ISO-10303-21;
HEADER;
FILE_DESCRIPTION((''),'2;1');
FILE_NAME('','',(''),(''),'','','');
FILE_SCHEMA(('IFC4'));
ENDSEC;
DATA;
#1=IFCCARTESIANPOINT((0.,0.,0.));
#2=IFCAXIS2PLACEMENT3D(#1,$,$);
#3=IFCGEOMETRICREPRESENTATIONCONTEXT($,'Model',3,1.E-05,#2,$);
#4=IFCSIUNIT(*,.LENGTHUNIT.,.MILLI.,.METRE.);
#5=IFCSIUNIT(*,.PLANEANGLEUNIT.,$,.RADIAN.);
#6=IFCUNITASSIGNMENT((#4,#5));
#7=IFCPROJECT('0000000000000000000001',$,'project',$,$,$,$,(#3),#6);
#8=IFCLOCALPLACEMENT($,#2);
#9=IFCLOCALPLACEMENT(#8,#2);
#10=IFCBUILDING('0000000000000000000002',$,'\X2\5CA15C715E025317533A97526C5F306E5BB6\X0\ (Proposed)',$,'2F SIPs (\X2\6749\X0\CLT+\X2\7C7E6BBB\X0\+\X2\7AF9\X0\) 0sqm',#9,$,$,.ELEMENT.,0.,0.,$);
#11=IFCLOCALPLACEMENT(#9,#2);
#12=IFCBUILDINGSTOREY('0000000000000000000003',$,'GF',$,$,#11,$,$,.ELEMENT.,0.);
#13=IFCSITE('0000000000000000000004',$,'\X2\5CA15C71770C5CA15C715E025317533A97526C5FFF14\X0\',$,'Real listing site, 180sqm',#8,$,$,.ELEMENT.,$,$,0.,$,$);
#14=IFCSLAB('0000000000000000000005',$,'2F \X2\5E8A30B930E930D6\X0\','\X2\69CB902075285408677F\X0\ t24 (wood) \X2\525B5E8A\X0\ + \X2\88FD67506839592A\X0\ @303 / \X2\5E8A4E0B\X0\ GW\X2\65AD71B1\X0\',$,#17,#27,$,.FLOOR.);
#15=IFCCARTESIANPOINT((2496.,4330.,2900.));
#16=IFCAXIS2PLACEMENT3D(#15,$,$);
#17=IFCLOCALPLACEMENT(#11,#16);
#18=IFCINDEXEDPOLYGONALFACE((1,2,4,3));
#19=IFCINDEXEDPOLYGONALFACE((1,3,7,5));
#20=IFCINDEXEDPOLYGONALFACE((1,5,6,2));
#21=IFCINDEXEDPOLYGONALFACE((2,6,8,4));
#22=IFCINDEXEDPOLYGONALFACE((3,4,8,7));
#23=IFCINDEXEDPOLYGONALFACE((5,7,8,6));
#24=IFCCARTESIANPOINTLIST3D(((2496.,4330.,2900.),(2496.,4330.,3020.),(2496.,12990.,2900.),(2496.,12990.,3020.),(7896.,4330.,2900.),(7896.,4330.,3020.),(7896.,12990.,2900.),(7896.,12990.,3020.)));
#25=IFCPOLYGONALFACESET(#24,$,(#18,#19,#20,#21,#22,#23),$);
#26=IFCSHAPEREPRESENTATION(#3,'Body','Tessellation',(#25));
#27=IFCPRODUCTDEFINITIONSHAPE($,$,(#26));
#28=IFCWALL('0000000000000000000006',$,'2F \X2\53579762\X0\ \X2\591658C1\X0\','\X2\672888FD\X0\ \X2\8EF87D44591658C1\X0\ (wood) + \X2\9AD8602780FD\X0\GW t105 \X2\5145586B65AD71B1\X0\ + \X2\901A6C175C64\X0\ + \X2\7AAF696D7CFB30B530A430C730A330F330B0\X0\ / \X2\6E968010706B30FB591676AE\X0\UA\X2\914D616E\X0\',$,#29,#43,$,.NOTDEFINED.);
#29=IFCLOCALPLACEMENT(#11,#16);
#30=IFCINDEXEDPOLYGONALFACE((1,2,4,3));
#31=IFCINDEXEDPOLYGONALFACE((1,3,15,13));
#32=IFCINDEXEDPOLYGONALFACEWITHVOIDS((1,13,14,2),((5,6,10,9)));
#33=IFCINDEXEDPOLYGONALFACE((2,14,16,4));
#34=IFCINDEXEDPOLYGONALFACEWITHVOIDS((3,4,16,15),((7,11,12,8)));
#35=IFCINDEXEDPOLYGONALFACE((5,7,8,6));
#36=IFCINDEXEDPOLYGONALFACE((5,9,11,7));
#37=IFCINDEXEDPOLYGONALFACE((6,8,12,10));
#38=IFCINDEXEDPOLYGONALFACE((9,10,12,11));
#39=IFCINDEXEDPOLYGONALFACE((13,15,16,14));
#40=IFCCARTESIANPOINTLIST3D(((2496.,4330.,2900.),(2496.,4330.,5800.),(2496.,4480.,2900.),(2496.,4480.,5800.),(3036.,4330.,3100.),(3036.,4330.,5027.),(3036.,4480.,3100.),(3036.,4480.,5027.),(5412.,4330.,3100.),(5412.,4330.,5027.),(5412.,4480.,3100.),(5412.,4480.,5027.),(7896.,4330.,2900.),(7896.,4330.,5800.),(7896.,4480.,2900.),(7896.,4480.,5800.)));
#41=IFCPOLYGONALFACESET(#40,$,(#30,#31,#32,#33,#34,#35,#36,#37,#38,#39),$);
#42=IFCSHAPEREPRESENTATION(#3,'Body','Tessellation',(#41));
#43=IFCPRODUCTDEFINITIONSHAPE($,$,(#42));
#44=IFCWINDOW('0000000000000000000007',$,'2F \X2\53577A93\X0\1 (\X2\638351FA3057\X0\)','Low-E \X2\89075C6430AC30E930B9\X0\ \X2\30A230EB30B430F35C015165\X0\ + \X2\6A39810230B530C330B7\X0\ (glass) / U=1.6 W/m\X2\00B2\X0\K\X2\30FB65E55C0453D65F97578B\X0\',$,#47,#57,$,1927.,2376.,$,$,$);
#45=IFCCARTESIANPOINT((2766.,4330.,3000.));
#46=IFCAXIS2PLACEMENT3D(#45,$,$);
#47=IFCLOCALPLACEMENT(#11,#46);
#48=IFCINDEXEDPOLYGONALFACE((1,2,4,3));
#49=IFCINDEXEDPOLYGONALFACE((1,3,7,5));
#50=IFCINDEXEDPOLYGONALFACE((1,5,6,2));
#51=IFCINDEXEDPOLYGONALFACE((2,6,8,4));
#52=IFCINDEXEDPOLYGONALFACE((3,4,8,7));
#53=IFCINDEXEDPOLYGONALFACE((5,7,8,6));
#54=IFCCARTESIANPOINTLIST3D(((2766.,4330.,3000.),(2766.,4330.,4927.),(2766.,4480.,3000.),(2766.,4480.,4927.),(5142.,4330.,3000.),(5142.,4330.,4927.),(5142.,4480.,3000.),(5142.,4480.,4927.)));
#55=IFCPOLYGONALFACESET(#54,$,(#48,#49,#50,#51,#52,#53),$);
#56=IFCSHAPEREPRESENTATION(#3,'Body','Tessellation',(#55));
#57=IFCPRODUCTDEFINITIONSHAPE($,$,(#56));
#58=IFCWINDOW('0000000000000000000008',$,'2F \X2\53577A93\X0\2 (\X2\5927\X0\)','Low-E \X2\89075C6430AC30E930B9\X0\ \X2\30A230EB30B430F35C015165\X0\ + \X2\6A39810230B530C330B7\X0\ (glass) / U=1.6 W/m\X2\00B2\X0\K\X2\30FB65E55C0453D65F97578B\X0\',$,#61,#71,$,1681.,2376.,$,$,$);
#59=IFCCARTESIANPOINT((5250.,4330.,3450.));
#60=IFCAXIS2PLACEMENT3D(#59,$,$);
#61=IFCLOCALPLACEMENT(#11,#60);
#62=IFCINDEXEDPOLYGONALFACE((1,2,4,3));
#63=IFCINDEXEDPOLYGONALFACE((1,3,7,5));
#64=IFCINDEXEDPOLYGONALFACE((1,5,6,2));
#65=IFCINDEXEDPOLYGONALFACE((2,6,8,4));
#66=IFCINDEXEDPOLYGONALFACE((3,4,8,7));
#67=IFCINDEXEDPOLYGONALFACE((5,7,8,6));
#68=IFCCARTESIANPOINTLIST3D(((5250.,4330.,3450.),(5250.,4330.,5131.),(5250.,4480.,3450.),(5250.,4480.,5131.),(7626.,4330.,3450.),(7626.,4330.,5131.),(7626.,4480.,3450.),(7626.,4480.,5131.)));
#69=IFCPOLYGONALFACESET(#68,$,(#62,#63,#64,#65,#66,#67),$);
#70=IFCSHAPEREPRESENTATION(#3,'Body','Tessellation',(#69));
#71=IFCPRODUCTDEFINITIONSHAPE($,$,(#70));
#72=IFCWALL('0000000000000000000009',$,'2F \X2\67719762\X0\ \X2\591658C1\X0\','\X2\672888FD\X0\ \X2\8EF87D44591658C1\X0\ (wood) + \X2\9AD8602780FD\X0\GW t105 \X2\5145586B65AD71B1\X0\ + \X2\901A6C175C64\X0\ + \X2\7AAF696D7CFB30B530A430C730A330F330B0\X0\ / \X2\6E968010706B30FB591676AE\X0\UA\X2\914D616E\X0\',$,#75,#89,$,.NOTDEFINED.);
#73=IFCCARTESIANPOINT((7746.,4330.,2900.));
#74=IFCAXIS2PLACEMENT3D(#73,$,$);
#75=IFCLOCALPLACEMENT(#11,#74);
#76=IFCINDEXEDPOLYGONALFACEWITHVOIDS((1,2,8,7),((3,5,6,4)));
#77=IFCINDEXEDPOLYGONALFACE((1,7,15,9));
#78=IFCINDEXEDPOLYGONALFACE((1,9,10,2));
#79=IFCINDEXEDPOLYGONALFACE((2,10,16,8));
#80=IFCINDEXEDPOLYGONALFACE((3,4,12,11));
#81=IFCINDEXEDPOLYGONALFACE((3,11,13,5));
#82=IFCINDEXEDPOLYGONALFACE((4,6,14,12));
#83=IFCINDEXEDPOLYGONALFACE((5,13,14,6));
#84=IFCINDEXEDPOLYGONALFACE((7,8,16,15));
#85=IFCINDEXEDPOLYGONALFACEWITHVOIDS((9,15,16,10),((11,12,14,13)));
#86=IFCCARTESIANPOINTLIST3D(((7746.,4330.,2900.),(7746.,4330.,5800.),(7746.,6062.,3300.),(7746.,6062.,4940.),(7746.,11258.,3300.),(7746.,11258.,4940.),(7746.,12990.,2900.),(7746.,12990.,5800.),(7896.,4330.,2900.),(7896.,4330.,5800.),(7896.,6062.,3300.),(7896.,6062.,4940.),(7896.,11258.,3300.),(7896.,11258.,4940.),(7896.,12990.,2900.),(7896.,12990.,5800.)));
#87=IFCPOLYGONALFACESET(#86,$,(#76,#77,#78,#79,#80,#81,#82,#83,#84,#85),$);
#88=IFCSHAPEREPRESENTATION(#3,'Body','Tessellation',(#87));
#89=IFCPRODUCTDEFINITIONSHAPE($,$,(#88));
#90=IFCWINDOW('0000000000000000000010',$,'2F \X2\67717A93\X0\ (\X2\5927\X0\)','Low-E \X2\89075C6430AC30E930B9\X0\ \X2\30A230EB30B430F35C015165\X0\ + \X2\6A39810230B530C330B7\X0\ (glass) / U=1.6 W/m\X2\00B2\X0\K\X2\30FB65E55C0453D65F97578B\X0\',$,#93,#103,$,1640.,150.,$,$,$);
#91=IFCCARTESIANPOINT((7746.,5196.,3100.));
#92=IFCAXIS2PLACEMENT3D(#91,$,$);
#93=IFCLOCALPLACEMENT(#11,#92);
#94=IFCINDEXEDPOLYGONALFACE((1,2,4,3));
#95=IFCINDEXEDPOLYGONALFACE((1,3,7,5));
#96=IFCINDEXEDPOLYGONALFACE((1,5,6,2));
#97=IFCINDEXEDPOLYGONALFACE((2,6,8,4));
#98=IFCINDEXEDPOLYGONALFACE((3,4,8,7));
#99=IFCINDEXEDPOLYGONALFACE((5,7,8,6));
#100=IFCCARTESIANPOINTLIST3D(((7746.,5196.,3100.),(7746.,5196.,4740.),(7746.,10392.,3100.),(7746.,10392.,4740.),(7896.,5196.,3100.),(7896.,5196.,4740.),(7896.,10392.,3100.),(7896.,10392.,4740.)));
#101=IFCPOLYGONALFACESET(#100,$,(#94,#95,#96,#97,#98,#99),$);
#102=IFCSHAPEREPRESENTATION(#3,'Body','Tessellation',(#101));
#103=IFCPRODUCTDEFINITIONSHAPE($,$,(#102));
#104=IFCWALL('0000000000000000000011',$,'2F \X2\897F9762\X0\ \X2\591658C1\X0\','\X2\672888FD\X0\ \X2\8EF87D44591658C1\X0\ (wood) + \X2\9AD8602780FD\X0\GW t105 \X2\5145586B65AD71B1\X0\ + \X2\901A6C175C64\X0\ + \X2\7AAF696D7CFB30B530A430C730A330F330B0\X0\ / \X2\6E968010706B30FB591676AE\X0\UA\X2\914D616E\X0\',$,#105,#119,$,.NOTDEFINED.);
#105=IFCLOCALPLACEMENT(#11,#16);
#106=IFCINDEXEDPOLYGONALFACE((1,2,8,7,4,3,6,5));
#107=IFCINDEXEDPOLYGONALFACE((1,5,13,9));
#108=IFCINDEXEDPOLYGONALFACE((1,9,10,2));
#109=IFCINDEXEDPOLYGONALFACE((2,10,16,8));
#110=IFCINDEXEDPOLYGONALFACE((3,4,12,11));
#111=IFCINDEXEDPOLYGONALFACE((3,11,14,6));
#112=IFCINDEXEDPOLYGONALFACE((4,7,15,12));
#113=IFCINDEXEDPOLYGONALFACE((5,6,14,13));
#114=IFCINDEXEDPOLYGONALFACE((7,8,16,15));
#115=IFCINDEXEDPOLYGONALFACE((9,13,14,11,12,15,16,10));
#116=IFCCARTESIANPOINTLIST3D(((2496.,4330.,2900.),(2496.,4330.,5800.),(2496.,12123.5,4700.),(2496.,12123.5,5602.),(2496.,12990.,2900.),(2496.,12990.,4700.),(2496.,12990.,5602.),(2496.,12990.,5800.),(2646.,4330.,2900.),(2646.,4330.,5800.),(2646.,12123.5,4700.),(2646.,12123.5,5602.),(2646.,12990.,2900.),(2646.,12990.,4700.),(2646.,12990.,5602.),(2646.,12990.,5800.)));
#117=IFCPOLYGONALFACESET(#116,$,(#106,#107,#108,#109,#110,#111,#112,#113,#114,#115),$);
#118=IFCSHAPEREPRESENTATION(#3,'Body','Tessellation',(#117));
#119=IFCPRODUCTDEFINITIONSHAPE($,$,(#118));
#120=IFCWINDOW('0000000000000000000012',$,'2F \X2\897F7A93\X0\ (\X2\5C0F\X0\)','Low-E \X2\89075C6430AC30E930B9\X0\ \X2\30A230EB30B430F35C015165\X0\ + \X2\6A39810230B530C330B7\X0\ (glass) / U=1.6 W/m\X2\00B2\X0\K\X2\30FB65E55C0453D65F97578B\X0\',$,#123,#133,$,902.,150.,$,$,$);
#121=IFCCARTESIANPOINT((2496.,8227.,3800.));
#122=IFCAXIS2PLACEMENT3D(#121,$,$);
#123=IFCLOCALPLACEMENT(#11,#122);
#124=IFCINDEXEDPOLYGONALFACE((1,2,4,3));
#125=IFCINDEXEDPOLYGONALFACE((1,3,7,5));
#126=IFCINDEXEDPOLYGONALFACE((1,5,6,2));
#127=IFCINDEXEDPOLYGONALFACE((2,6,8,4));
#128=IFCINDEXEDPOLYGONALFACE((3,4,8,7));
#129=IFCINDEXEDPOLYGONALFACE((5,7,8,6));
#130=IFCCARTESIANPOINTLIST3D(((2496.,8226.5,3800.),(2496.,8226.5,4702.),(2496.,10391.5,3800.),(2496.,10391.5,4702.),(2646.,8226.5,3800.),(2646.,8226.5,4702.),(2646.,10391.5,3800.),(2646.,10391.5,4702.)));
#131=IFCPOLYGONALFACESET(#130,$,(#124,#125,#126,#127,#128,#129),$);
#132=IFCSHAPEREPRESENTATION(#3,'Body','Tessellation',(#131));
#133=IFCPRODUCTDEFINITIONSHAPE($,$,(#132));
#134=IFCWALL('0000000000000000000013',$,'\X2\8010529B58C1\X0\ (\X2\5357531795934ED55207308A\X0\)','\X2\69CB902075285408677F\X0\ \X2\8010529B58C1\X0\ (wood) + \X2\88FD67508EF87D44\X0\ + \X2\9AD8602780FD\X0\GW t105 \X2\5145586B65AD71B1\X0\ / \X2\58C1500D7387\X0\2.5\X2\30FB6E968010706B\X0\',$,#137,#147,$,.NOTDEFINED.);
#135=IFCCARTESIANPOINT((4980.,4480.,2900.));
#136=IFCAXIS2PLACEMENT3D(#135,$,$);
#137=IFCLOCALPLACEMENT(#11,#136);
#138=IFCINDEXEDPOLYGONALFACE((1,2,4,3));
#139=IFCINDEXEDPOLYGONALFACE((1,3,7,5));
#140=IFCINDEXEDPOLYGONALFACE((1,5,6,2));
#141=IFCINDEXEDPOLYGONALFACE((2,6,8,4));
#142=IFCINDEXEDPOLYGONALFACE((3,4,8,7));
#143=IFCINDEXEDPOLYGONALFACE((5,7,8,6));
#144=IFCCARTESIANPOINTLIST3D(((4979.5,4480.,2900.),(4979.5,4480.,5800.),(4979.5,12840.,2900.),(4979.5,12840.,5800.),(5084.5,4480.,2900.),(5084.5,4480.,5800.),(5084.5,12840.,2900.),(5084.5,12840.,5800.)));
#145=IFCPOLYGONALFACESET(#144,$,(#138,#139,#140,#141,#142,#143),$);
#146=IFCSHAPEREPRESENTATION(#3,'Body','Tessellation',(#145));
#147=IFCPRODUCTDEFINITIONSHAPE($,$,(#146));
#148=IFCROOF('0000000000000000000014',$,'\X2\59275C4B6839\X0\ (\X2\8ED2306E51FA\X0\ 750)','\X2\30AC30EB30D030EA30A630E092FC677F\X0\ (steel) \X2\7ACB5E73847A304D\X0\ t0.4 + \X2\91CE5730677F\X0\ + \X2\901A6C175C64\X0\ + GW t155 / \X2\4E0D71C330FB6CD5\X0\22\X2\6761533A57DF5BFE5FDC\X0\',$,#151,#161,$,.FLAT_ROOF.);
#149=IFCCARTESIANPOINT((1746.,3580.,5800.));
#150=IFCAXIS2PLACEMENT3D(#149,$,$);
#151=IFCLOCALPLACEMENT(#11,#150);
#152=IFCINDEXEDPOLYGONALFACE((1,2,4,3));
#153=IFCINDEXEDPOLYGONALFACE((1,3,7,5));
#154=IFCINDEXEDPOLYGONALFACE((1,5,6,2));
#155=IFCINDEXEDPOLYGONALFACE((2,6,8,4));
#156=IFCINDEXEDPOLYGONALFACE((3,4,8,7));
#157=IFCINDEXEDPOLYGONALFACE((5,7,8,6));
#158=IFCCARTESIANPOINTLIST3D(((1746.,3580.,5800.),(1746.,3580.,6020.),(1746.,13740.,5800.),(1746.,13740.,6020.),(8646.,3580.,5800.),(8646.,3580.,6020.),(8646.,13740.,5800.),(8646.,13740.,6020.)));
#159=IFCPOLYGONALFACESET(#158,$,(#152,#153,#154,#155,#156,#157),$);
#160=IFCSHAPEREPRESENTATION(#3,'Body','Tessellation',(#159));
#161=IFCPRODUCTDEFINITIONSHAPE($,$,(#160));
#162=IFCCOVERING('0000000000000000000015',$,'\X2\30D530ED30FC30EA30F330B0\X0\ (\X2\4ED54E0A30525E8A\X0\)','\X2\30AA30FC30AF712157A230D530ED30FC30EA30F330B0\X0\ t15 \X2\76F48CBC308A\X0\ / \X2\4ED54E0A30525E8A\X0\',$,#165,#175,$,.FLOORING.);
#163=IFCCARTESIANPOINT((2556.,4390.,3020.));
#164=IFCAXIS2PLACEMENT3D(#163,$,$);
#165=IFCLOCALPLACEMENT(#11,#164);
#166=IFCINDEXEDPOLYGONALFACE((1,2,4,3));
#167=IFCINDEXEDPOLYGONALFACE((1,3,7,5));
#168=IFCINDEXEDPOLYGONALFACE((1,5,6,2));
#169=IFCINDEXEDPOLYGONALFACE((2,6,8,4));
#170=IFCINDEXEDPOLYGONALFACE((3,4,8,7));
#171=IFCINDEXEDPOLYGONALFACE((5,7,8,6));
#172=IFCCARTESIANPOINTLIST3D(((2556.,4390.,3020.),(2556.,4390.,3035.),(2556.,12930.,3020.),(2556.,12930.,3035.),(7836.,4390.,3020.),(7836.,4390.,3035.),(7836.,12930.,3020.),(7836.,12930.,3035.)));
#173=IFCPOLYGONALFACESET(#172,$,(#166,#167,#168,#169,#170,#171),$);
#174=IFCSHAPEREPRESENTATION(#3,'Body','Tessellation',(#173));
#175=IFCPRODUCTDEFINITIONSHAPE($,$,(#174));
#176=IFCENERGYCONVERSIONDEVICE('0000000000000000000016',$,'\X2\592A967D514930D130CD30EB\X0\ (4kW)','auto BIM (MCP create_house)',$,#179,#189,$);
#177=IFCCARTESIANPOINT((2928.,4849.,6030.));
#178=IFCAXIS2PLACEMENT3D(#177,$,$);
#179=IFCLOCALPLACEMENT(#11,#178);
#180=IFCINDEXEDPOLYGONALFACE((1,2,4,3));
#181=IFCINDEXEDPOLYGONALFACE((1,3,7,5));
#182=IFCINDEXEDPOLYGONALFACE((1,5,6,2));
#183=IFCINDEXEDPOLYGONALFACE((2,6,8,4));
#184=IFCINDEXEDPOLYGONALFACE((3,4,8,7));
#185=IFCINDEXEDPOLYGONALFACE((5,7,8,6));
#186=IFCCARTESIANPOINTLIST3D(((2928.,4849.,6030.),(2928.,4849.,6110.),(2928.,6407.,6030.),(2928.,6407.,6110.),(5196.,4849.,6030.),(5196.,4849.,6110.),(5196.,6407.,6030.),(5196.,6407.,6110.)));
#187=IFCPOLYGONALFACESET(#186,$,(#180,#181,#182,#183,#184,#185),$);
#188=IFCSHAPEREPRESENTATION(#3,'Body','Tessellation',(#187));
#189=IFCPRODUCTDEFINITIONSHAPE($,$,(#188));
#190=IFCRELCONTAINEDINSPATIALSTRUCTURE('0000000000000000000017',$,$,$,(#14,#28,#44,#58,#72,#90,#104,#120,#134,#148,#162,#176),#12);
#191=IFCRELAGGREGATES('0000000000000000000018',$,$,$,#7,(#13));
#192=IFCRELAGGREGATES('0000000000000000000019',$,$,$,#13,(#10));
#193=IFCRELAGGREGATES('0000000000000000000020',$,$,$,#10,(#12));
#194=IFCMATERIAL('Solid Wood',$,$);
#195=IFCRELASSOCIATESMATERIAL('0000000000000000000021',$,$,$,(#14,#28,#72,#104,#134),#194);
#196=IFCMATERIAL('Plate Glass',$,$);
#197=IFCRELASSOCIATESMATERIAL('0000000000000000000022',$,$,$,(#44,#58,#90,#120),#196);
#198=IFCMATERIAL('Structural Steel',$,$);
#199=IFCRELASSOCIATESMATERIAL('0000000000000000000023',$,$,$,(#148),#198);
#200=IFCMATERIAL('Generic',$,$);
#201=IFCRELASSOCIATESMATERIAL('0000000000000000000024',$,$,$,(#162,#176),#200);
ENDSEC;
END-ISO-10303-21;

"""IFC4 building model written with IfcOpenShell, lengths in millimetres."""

from ifc_helpers import new_model, si_unit, frame, frame_2d, origin, place, context, project, spatial, rectangle, extrude, material, element, fill, save


model = new_model("IFC4")

# Units and contexts
model_context = context("Model", 3, precision=1e-05, world=origin())
ifc_project = project(units=[si_unit("LENGTHUNIT", "METRE", prefix="MILLI"), si_unit("PLANEANGLEUNIT", "RADIAN")], contexts=[model_context])

# Site, building, storey
site_placement = place(None, origin())
site = spatial("IfcSite", under=ifc_project, at=site_placement, Name="岡山県岡山市北区青江４", ObjectType="Real listing site, 180sqm", CompositionType="ELEMENT", RefElevation=0.0)
building_placement = place(site_placement, origin())
building = spatial("IfcBuilding", under=site, at=building_placement, Name="岡山市北区青江の家 (Proposed)", ObjectType="2F SIPs (杉CLT+籾殻+竹) 0sqm", CompositionType="ELEMENT", ElevationOfRefHeight=0.0, ElevationOfTerrain=0.0)
storey_placement = place(building_placement, origin())
storey = spatial("IfcBuildingStorey", under=building, at=storey_placement, Name="GF", CompositionType="ELEMENT", Elevation=0.0)

# Slab
ifc_material_1 = material(Name="Solid Wood")
slab_placement = place(storey_placement, frame((2496.0, 4330.0, 2900.0)))
element("IfcSlab", 1, at=slab_placement, inside=storey, material=ifc_material_1, Name="2F 床スラブ", Description="構造用合板 t24 (wood) 剛床 + 製材根太 @303 / 床下 GW断熱", PredefinedType="FLOOR", context=model_context, shape_type="SweptSolid", body=[
    extrude(rectangle(XDim=5400.0, YDim=8660.0, at=frame_2d((2700.0, 4330.0))), frame((2496.0, 4330.0, 2900.0)), (0.0, 0.0, 1.0), 120.0),
])

# Wall, openings, windows
wall_1_placement = place(storey_placement, frame((2496.0, 4330.0, 2900.0)))
wall_1 = element("IfcWall", 2, at=wall_1_placement, inside=storey, material=ifc_material_1, Name="2F 南面 外壁", Description="木製 軸組外壁 (wood) + 高性能GW t105 充填断熱 + 通気層 + 窯業系サイディング / 準耐火・外皮UA配慮", PredefinedType="NOTDEFINED", context=model_context, shape_type="SweptSolid", body=[
    extrude(rectangle(XDim=5400.0, YDim=150.0, at=frame_2d((2700.0, 75.0))), frame((2496.0, 4330.0, 2900.0)), (0.0, 0.0, 1.0), 2900.0),
])
opening_1_placement = place(storey_placement, frame((2766.0, 4330.0, 3000.0)))
opening_1 = element("IfcOpeningElement", 3, at=opening_1_placement, cuts=wall_1, PredefinedType="NOTDEFINED", context=model_context, shape_type="SweptSolid", body=[
    extrude(rectangle(XDim=2376.0, YDim=150.0, at=frame_2d((1188.0, 75.0))), frame((2766.0, 4330.0, 3000.0)), (0.0, 0.0, 1.0), 1927.0),
])
opening_2_placement = place(storey_placement, frame((5250.0, 4330.0, 3450.0)))
opening_2 = element("IfcOpeningElement", 4, at=opening_2_placement, cuts=wall_1, PredefinedType="NOTDEFINED", context=model_context, shape_type="SweptSolid", body=[
    extrude(rectangle(XDim=2376.0, YDim=150.0, at=frame_2d((1188.0, 75.0))), frame((5250.0, 4330.0, 3450.0)), (0.0, 0.0, 1.0), 1681.0),
])
ifc_material_2 = material(Name="Plate Glass")
window_1_placement = place(storey_placement, frame((2766.0, 4330.0, 3000.0)))
window_1 = element("IfcWindow", 5, at=window_1_placement, inside=storey, material=ifc_material_2, Name="2F 南窓1 (掃出し)", Description="Low-E 複層ガラス アルゴン封入 + 樹脂サッシ (glass) / U=1.6 W/m²K・日射取得型", OverallHeight=1927.0, OverallWidth=2376.0, context=model_context, shape_type="SweptSolid", body=[
    extrude(rectangle(XDim=2376.0, YDim=150.0, at=frame_2d((1188.0, 75.0))), frame((2766.0, 4330.0, 3000.0)), (0.0, 0.0, 1.0), 1927.0),
])
fill(opening_1, window_1)
window_2_placement = place(storey_placement, frame((5250.0, 4330.0, 3450.0)))
window_2 = element("IfcWindow", 6, at=window_2_placement, inside=storey, material=ifc_material_2, Name="2F 南窓2 (大)", Description="Low-E 複層ガラス アルゴン封入 + 樹脂サッシ (glass) / U=1.6 W/m²K・日射取得型", OverallHeight=1681.0, OverallWidth=2376.0, context=model_context, shape_type="SweptSolid", body=[
    extrude(rectangle(XDim=2376.0, YDim=150.0, at=frame_2d((1188.0, 75.0))), frame((5250.0, 4330.0, 3450.0)), (0.0, 0.0, 1.0), 1681.0),
])
fill(opening_2, window_2)

# Walls, openings, windows
wall_2_placement = place(storey_placement, frame((7746.0, 4330.0, 2900.0)))
wall_2 = element("IfcWall", 7, at=wall_2_placement, inside=storey, material=ifc_material_1, Name="2F 東面 外壁", Description="木製 軸組外壁 (wood) + 高性能GW t105 充填断熱 + 通気層 + 窯業系サイディング / 準耐火・外皮UA配慮", PredefinedType="NOTDEFINED", context=model_context, shape_type="SweptSolid", body=[
    extrude(rectangle(XDim=150.0, YDim=8660.0, at=frame_2d((75.0, 4330.0))), frame((7746.0, 4330.0, 2900.0)), (0.0, 0.0, 1.0), 2900.0),
])
opening_3_placement = place(storey_placement, frame((7746.0, 5196.0, 3100.0)))
opening_3 = element("IfcOpeningElement", 8, at=opening_3_placement, cuts=wall_2, PredefinedType="NOTDEFINED", context=model_context, shape_type="SweptSolid", body=[
    extrude(rectangle(XDim=150.0, YDim=5196.0, at=frame_2d((75.0, 2598.0))), frame((7746.0, 5196.0, 3100.0)), (0.0, 0.0, 1.0), 1640.0),
])
window_3_placement = place(storey_placement, frame((7746.0, 5196.0, 3100.0)))
window_3 = element("IfcWindow", 9, at=window_3_placement, inside=storey, material=ifc_material_2, Name="2F 東窓 (大)", Description="Low-E 複層ガラス アルゴン封入 + 樹脂サッシ (glass) / U=1.6 W/m²K・日射取得型", OverallHeight=1640.0, OverallWidth=150.0, context=model_context, shape_type="SweptSolid", body=[
    extrude(rectangle(XDim=150.0, YDim=5196.0, at=frame_2d((75.0, 2598.0))), frame((7746.0, 5196.0, 3100.0)), (0.0, 0.0, 1.0), 1640.0),
])
fill(opening_3, window_3)
wall_3_placement = place(storey_placement, frame((2496.0, 4330.0, 2900.0)))
wall_3 = element("IfcWall", 10, at=wall_3_placement, inside=storey, material=ifc_material_1, Name="2F 西面 外壁", Description="木製 軸組外壁 (wood) + 高性能GW t105 充填断熱 + 通気層 + 窯業系サイディング / 準耐火・外皮UA配慮", PredefinedType="NOTDEFINED", context=model_context, shape_type="SweptSolid", body=[
    extrude(rectangle(XDim=150.0, YDim=8660.0, at=frame_2d((75.0, 4330.0))), frame((2496.0, 4330.0, 2900.0)), (0.0, 0.0, 1.0), 2900.0),
])
opening_4_placement = place(storey_placement, frame((2496.0, 8227.0, 3800.0)))
opening_4 = element("IfcOpeningElement", 11, at=opening_4_placement, cuts=wall_3, PredefinedType="NOTDEFINED", context=model_context, shape_type="SweptSolid", body=[
    extrude(rectangle(XDim=150.0, YDim=2165.0, at=frame_2d((75.0, 1082.0))), frame((2496.0, 8227.0, 3800.0)), (0.0, 0.0, 1.0), 902.0),
])
window_4_placement = place(storey_placement, frame((2496.0, 8227.0, 3800.0)))
window_4 = element("IfcWindow", 12, at=window_4_placement, inside=storey, material=ifc_material_2, Name="2F 西窓 (小)", Description="Low-E 複層ガラス アルゴン封入 + 樹脂サッシ (glass) / U=1.6 W/m²K・日射取得型", OverallHeight=902.0, OverallWidth=150.0, context=model_context, shape_type="SweptSolid", body=[
    extrude(rectangle(XDim=150.0, YDim=2165.0, at=frame_2d((75.0, 1082.0))), frame((2496.0, 8227.0, 3800.0)), (0.0, 0.0, 1.0), 902.0),
])
fill(opening_4, window_4)

# Wall
wall_4_placement = place(storey_placement, frame((4980.0, 4480.0, 2900.0)))
element("IfcWall", 13, at=wall_4_placement, inside=storey, material=ifc_material_1, Name="耐力壁 (南北間仕切り)", Description="構造用合板 耐力壁 (wood) + 製材軸組 + 高性能GW t105 充填断熱 / 壁倍率2.5・準耐火", PredefinedType="NOTDEFINED", context=model_context, shape_type="SweptSolid", body=[
    extrude(rectangle(XDim=105.0, YDim=8360.0, at=frame_2d((52.0, 4180.0))), frame((4980.0, 4480.0, 2900.0)), (0.0, 0.0, 1.0), 2900.0),
])

# Roof
ifc_material_3 = material(Name="Structural Steel")
roof_placement = place(storey_placement, frame((1746.0, 3580.0, 5800.0)))
element("IfcRoof", 14, at=roof_placement, inside=storey, material=ifc_material_3, Name="大屋根 (軒の出 750)", Description="ガルバリウム鋼板 (steel) 立平葺き t0.4 + 野地板 + 通気層 + GW t155 / 不燃・法22条区域対応", PredefinedType="FLAT_ROOF", context=model_context, shape_type="SweptSolid", body=[
    extrude(rectangle(XDim=6900.0, YDim=10160.0, at=frame_2d((3450.0, 5080.0))), frame((1746.0, 3580.0, 5800.0)), (0.0, 0.0, 1.0), 220.0),
])

# Covering
ifc_material_4 = material(Name="Generic")
covering_placement = place(storey_placement, frame((2556.0, 4390.0, 3020.0)))
element("IfcCovering", 15, at=covering_placement, inside=storey, material=ifc_material_4, Name="フローリング (仕上げ床)", Description="オーク無垢フローリング t15 直貼り / 仕上げ床", PredefinedType="FLOORING", context=model_context, shape_type="SweptSolid", body=[
    extrude(rectangle(XDim=5280.0, YDim=8540.0, at=frame_2d((2640.0, 4270.0))), frame((2556.0, 4390.0, 3020.0)), (0.0, 0.0, 1.0), 15.0),
])

# Energy conversion device
energy_conversion_device_placement = place(storey_placement, frame((2928.0, 4849.0, 6030.0)))
element("IfcEnergyConversionDevice", 16, at=energy_conversion_device_placement, inside=storey, material=ifc_material_4, Name="太陽光パネル (4kW)", Description="auto BIM (MCP create_house)", context=model_context, shape_type="SweptSolid", body=[
    extrude(rectangle(XDim=2268.0, YDim=1558.0, at=frame_2d((1134.0, 779.0))), frame((2928.0, 4849.0, 6030.0)), (0.0, 0.0, 1.0), 80.0),
])

save(model, "model.ifc")
